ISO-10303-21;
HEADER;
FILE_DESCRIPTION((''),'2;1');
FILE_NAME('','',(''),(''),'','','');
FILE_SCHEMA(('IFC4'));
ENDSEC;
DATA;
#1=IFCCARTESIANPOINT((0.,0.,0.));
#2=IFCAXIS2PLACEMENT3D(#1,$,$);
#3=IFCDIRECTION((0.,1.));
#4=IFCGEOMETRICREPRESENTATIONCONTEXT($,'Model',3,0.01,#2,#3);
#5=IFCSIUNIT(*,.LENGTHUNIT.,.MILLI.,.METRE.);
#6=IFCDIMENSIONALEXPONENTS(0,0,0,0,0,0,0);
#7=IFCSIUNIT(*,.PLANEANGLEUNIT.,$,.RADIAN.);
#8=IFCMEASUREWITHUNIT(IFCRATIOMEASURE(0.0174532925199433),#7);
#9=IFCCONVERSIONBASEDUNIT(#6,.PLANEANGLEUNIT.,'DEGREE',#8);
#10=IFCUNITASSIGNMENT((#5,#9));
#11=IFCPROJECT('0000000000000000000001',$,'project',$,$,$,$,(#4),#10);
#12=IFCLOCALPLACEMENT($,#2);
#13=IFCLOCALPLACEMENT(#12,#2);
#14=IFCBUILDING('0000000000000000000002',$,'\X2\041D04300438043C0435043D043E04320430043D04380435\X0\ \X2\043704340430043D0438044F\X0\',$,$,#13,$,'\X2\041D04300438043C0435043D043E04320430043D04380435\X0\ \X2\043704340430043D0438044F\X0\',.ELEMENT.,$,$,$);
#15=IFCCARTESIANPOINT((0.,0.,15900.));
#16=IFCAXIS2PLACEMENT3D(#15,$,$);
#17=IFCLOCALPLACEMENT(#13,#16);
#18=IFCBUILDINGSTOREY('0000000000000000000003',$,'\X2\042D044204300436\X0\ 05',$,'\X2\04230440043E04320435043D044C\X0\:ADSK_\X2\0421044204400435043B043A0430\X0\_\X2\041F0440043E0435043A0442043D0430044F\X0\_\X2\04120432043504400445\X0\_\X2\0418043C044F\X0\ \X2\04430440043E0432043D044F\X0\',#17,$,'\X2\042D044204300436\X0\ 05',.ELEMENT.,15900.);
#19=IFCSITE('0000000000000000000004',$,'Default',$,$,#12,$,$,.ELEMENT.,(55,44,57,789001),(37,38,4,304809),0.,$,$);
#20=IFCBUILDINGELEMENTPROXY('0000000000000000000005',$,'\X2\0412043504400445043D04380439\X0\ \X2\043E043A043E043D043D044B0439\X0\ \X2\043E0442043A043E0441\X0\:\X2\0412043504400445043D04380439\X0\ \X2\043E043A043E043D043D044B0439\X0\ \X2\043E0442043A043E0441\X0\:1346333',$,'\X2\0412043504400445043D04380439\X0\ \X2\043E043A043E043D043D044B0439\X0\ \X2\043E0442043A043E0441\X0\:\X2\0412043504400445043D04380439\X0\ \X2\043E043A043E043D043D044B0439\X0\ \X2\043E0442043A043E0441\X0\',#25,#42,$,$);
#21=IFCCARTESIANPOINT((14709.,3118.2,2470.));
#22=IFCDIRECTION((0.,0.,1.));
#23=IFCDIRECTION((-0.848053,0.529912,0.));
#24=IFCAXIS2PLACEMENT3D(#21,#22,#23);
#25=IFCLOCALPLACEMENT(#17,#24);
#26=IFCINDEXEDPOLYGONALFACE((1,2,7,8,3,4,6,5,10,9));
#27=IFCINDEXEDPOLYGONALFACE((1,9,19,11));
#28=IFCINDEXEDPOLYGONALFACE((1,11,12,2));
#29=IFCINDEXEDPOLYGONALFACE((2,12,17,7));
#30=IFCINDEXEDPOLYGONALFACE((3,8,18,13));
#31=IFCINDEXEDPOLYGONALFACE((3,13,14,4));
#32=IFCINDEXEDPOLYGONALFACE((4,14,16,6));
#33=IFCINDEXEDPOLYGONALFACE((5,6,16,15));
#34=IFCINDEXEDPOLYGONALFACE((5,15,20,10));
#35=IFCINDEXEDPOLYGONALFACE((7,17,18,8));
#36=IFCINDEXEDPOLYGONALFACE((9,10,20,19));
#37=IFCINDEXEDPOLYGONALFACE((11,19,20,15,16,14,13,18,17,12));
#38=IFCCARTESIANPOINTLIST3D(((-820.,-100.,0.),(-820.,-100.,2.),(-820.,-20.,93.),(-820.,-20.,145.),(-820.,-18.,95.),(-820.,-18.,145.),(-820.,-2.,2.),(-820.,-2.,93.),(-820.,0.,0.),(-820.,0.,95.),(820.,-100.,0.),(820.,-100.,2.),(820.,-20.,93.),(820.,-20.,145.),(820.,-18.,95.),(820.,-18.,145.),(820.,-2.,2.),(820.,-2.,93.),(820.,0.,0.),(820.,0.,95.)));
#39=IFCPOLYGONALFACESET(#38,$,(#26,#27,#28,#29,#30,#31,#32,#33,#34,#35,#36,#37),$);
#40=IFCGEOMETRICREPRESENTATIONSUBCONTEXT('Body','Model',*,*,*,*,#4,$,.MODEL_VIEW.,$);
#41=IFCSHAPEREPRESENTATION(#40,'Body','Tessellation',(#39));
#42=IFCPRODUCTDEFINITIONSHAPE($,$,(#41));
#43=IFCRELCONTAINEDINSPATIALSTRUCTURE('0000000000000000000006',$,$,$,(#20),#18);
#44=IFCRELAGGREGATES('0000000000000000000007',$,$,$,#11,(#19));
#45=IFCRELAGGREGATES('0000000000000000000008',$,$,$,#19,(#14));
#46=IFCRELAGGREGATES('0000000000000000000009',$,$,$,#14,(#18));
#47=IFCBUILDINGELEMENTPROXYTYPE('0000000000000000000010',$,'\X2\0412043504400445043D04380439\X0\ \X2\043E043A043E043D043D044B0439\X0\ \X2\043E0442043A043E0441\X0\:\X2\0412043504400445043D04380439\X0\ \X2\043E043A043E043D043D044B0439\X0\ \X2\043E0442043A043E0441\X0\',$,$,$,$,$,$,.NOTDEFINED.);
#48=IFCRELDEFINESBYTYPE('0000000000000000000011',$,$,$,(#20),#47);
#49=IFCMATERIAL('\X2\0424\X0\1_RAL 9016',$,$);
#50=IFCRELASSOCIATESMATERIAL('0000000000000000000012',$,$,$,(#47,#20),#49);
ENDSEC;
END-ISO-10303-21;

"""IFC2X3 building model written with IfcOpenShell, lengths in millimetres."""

from ifc_helpers import new_model, entity, si_unit, converted_unit, direction, frame, origin, place, context, subcontext, project, spatial, polyline, outline, extrude, source, transform, mapped, material, type_object, type_shapes, element, save


model = new_model("IFC2X3")

# Units and contexts
model_context = context("Model", 3, precision=0.01, world=origin(), true_north=direction((0.0, 1.0)))
body_context = subcontext(model_context, "Body", "Model", "MODEL_VIEW")
ifc_project = project(units=[si_unit("LENGTHUNIT", "METRE", prefix="MILLI"), converted_unit("PLANEANGLEUNIT", "DEGREE", entity("IfcRatioMeasure", 0.0174532925199433), si_unit("PLANEANGLEUNIT", "RADIAN"), dimensions=[0, 0, 0, 0, 0, 0, 0])], contexts=[model_context])

# Site, building, storey
site_placement = place(None, origin())
site = spatial("IfcSite", under=ifc_project, at=site_placement, Name="Default", CompositionType="ELEMENT", RefLatitude=(55, 44, 57, 789001), RefLongitude=(37, 38, 4, 304809), RefElevation=0.0)
building_placement = place(site_placement, origin())
building = spatial("IfcBuilding", under=site, at=building_placement, Name="Наименование здания", LongName="Наименование здания", CompositionType="ELEMENT")
storey_placement = place(building_placement, frame((0.0, 0.0, 15900.0)))
storey = spatial("IfcBuildingStorey", under=building, at=storey_placement, Name="Этаж 05", ObjectType="Уровень:ADSK_Стрелка_Проектная_Вверх_Имя уровня", LongName="Этаж 05", CompositionType="ELEMENT", Elevation=15900.0)

# Building element proxy
ifc_material_1 = material(Name="Ф1_RAL 9016")
building_element_proxy_type_1 = type_object("IfcBuildingElementProxyType", Name="Верхний оконный откос:Верхний оконный откос", PredefinedType="NOTDEFINED", material=ifc_material_1)
shared_shape_1 = source(origin(), body_context, "Body", "SweptSolid", [
    extrude(outline(polyline([(28.0, -10.0), (78.0, -10.0), (78.0, -8.0), (26.0, -8.0), (26.0, -26.0), (-65.0, -26.0), (-65.0, 72.0), (-67.0, 72.0), (-67.0, -28.0), (28.0, -28.0), (28.0, -10.0)])), frame((-820.0, -28.0, 67.0), z_axis=(1.0, 0.0, 0.0), x_axis=(0.0, 0.0, 1.0)), (0.0, 0.0, 1.0), 1640.0),
])
type_shapes(building_element_proxy_type_1, [shared_shape_1])
proxy_1_placement = place(storey_placement, frame((14709.0, 3118.2, 2470.0), z_axis=(0.0, 0.0, 1.0), x_axis=(-0.848053, 0.529912, 0.0)))
element("IfcBuildingElementProxy", 1, at=proxy_1_placement, inside=storey, type_object=building_element_proxy_type_1, material=ifc_material_1, Name="Верхний оконный откос:Верхний оконный откос:1346333", ObjectType="Верхний оконный откос:Верхний оконный откос", context=body_context, shape_type="MappedRepresentation", body=[
    mapped(shared_shape_1, transform((0.0, 0.0, 0.0), scale=1.0)),
])

save(model, "model.ifc")
